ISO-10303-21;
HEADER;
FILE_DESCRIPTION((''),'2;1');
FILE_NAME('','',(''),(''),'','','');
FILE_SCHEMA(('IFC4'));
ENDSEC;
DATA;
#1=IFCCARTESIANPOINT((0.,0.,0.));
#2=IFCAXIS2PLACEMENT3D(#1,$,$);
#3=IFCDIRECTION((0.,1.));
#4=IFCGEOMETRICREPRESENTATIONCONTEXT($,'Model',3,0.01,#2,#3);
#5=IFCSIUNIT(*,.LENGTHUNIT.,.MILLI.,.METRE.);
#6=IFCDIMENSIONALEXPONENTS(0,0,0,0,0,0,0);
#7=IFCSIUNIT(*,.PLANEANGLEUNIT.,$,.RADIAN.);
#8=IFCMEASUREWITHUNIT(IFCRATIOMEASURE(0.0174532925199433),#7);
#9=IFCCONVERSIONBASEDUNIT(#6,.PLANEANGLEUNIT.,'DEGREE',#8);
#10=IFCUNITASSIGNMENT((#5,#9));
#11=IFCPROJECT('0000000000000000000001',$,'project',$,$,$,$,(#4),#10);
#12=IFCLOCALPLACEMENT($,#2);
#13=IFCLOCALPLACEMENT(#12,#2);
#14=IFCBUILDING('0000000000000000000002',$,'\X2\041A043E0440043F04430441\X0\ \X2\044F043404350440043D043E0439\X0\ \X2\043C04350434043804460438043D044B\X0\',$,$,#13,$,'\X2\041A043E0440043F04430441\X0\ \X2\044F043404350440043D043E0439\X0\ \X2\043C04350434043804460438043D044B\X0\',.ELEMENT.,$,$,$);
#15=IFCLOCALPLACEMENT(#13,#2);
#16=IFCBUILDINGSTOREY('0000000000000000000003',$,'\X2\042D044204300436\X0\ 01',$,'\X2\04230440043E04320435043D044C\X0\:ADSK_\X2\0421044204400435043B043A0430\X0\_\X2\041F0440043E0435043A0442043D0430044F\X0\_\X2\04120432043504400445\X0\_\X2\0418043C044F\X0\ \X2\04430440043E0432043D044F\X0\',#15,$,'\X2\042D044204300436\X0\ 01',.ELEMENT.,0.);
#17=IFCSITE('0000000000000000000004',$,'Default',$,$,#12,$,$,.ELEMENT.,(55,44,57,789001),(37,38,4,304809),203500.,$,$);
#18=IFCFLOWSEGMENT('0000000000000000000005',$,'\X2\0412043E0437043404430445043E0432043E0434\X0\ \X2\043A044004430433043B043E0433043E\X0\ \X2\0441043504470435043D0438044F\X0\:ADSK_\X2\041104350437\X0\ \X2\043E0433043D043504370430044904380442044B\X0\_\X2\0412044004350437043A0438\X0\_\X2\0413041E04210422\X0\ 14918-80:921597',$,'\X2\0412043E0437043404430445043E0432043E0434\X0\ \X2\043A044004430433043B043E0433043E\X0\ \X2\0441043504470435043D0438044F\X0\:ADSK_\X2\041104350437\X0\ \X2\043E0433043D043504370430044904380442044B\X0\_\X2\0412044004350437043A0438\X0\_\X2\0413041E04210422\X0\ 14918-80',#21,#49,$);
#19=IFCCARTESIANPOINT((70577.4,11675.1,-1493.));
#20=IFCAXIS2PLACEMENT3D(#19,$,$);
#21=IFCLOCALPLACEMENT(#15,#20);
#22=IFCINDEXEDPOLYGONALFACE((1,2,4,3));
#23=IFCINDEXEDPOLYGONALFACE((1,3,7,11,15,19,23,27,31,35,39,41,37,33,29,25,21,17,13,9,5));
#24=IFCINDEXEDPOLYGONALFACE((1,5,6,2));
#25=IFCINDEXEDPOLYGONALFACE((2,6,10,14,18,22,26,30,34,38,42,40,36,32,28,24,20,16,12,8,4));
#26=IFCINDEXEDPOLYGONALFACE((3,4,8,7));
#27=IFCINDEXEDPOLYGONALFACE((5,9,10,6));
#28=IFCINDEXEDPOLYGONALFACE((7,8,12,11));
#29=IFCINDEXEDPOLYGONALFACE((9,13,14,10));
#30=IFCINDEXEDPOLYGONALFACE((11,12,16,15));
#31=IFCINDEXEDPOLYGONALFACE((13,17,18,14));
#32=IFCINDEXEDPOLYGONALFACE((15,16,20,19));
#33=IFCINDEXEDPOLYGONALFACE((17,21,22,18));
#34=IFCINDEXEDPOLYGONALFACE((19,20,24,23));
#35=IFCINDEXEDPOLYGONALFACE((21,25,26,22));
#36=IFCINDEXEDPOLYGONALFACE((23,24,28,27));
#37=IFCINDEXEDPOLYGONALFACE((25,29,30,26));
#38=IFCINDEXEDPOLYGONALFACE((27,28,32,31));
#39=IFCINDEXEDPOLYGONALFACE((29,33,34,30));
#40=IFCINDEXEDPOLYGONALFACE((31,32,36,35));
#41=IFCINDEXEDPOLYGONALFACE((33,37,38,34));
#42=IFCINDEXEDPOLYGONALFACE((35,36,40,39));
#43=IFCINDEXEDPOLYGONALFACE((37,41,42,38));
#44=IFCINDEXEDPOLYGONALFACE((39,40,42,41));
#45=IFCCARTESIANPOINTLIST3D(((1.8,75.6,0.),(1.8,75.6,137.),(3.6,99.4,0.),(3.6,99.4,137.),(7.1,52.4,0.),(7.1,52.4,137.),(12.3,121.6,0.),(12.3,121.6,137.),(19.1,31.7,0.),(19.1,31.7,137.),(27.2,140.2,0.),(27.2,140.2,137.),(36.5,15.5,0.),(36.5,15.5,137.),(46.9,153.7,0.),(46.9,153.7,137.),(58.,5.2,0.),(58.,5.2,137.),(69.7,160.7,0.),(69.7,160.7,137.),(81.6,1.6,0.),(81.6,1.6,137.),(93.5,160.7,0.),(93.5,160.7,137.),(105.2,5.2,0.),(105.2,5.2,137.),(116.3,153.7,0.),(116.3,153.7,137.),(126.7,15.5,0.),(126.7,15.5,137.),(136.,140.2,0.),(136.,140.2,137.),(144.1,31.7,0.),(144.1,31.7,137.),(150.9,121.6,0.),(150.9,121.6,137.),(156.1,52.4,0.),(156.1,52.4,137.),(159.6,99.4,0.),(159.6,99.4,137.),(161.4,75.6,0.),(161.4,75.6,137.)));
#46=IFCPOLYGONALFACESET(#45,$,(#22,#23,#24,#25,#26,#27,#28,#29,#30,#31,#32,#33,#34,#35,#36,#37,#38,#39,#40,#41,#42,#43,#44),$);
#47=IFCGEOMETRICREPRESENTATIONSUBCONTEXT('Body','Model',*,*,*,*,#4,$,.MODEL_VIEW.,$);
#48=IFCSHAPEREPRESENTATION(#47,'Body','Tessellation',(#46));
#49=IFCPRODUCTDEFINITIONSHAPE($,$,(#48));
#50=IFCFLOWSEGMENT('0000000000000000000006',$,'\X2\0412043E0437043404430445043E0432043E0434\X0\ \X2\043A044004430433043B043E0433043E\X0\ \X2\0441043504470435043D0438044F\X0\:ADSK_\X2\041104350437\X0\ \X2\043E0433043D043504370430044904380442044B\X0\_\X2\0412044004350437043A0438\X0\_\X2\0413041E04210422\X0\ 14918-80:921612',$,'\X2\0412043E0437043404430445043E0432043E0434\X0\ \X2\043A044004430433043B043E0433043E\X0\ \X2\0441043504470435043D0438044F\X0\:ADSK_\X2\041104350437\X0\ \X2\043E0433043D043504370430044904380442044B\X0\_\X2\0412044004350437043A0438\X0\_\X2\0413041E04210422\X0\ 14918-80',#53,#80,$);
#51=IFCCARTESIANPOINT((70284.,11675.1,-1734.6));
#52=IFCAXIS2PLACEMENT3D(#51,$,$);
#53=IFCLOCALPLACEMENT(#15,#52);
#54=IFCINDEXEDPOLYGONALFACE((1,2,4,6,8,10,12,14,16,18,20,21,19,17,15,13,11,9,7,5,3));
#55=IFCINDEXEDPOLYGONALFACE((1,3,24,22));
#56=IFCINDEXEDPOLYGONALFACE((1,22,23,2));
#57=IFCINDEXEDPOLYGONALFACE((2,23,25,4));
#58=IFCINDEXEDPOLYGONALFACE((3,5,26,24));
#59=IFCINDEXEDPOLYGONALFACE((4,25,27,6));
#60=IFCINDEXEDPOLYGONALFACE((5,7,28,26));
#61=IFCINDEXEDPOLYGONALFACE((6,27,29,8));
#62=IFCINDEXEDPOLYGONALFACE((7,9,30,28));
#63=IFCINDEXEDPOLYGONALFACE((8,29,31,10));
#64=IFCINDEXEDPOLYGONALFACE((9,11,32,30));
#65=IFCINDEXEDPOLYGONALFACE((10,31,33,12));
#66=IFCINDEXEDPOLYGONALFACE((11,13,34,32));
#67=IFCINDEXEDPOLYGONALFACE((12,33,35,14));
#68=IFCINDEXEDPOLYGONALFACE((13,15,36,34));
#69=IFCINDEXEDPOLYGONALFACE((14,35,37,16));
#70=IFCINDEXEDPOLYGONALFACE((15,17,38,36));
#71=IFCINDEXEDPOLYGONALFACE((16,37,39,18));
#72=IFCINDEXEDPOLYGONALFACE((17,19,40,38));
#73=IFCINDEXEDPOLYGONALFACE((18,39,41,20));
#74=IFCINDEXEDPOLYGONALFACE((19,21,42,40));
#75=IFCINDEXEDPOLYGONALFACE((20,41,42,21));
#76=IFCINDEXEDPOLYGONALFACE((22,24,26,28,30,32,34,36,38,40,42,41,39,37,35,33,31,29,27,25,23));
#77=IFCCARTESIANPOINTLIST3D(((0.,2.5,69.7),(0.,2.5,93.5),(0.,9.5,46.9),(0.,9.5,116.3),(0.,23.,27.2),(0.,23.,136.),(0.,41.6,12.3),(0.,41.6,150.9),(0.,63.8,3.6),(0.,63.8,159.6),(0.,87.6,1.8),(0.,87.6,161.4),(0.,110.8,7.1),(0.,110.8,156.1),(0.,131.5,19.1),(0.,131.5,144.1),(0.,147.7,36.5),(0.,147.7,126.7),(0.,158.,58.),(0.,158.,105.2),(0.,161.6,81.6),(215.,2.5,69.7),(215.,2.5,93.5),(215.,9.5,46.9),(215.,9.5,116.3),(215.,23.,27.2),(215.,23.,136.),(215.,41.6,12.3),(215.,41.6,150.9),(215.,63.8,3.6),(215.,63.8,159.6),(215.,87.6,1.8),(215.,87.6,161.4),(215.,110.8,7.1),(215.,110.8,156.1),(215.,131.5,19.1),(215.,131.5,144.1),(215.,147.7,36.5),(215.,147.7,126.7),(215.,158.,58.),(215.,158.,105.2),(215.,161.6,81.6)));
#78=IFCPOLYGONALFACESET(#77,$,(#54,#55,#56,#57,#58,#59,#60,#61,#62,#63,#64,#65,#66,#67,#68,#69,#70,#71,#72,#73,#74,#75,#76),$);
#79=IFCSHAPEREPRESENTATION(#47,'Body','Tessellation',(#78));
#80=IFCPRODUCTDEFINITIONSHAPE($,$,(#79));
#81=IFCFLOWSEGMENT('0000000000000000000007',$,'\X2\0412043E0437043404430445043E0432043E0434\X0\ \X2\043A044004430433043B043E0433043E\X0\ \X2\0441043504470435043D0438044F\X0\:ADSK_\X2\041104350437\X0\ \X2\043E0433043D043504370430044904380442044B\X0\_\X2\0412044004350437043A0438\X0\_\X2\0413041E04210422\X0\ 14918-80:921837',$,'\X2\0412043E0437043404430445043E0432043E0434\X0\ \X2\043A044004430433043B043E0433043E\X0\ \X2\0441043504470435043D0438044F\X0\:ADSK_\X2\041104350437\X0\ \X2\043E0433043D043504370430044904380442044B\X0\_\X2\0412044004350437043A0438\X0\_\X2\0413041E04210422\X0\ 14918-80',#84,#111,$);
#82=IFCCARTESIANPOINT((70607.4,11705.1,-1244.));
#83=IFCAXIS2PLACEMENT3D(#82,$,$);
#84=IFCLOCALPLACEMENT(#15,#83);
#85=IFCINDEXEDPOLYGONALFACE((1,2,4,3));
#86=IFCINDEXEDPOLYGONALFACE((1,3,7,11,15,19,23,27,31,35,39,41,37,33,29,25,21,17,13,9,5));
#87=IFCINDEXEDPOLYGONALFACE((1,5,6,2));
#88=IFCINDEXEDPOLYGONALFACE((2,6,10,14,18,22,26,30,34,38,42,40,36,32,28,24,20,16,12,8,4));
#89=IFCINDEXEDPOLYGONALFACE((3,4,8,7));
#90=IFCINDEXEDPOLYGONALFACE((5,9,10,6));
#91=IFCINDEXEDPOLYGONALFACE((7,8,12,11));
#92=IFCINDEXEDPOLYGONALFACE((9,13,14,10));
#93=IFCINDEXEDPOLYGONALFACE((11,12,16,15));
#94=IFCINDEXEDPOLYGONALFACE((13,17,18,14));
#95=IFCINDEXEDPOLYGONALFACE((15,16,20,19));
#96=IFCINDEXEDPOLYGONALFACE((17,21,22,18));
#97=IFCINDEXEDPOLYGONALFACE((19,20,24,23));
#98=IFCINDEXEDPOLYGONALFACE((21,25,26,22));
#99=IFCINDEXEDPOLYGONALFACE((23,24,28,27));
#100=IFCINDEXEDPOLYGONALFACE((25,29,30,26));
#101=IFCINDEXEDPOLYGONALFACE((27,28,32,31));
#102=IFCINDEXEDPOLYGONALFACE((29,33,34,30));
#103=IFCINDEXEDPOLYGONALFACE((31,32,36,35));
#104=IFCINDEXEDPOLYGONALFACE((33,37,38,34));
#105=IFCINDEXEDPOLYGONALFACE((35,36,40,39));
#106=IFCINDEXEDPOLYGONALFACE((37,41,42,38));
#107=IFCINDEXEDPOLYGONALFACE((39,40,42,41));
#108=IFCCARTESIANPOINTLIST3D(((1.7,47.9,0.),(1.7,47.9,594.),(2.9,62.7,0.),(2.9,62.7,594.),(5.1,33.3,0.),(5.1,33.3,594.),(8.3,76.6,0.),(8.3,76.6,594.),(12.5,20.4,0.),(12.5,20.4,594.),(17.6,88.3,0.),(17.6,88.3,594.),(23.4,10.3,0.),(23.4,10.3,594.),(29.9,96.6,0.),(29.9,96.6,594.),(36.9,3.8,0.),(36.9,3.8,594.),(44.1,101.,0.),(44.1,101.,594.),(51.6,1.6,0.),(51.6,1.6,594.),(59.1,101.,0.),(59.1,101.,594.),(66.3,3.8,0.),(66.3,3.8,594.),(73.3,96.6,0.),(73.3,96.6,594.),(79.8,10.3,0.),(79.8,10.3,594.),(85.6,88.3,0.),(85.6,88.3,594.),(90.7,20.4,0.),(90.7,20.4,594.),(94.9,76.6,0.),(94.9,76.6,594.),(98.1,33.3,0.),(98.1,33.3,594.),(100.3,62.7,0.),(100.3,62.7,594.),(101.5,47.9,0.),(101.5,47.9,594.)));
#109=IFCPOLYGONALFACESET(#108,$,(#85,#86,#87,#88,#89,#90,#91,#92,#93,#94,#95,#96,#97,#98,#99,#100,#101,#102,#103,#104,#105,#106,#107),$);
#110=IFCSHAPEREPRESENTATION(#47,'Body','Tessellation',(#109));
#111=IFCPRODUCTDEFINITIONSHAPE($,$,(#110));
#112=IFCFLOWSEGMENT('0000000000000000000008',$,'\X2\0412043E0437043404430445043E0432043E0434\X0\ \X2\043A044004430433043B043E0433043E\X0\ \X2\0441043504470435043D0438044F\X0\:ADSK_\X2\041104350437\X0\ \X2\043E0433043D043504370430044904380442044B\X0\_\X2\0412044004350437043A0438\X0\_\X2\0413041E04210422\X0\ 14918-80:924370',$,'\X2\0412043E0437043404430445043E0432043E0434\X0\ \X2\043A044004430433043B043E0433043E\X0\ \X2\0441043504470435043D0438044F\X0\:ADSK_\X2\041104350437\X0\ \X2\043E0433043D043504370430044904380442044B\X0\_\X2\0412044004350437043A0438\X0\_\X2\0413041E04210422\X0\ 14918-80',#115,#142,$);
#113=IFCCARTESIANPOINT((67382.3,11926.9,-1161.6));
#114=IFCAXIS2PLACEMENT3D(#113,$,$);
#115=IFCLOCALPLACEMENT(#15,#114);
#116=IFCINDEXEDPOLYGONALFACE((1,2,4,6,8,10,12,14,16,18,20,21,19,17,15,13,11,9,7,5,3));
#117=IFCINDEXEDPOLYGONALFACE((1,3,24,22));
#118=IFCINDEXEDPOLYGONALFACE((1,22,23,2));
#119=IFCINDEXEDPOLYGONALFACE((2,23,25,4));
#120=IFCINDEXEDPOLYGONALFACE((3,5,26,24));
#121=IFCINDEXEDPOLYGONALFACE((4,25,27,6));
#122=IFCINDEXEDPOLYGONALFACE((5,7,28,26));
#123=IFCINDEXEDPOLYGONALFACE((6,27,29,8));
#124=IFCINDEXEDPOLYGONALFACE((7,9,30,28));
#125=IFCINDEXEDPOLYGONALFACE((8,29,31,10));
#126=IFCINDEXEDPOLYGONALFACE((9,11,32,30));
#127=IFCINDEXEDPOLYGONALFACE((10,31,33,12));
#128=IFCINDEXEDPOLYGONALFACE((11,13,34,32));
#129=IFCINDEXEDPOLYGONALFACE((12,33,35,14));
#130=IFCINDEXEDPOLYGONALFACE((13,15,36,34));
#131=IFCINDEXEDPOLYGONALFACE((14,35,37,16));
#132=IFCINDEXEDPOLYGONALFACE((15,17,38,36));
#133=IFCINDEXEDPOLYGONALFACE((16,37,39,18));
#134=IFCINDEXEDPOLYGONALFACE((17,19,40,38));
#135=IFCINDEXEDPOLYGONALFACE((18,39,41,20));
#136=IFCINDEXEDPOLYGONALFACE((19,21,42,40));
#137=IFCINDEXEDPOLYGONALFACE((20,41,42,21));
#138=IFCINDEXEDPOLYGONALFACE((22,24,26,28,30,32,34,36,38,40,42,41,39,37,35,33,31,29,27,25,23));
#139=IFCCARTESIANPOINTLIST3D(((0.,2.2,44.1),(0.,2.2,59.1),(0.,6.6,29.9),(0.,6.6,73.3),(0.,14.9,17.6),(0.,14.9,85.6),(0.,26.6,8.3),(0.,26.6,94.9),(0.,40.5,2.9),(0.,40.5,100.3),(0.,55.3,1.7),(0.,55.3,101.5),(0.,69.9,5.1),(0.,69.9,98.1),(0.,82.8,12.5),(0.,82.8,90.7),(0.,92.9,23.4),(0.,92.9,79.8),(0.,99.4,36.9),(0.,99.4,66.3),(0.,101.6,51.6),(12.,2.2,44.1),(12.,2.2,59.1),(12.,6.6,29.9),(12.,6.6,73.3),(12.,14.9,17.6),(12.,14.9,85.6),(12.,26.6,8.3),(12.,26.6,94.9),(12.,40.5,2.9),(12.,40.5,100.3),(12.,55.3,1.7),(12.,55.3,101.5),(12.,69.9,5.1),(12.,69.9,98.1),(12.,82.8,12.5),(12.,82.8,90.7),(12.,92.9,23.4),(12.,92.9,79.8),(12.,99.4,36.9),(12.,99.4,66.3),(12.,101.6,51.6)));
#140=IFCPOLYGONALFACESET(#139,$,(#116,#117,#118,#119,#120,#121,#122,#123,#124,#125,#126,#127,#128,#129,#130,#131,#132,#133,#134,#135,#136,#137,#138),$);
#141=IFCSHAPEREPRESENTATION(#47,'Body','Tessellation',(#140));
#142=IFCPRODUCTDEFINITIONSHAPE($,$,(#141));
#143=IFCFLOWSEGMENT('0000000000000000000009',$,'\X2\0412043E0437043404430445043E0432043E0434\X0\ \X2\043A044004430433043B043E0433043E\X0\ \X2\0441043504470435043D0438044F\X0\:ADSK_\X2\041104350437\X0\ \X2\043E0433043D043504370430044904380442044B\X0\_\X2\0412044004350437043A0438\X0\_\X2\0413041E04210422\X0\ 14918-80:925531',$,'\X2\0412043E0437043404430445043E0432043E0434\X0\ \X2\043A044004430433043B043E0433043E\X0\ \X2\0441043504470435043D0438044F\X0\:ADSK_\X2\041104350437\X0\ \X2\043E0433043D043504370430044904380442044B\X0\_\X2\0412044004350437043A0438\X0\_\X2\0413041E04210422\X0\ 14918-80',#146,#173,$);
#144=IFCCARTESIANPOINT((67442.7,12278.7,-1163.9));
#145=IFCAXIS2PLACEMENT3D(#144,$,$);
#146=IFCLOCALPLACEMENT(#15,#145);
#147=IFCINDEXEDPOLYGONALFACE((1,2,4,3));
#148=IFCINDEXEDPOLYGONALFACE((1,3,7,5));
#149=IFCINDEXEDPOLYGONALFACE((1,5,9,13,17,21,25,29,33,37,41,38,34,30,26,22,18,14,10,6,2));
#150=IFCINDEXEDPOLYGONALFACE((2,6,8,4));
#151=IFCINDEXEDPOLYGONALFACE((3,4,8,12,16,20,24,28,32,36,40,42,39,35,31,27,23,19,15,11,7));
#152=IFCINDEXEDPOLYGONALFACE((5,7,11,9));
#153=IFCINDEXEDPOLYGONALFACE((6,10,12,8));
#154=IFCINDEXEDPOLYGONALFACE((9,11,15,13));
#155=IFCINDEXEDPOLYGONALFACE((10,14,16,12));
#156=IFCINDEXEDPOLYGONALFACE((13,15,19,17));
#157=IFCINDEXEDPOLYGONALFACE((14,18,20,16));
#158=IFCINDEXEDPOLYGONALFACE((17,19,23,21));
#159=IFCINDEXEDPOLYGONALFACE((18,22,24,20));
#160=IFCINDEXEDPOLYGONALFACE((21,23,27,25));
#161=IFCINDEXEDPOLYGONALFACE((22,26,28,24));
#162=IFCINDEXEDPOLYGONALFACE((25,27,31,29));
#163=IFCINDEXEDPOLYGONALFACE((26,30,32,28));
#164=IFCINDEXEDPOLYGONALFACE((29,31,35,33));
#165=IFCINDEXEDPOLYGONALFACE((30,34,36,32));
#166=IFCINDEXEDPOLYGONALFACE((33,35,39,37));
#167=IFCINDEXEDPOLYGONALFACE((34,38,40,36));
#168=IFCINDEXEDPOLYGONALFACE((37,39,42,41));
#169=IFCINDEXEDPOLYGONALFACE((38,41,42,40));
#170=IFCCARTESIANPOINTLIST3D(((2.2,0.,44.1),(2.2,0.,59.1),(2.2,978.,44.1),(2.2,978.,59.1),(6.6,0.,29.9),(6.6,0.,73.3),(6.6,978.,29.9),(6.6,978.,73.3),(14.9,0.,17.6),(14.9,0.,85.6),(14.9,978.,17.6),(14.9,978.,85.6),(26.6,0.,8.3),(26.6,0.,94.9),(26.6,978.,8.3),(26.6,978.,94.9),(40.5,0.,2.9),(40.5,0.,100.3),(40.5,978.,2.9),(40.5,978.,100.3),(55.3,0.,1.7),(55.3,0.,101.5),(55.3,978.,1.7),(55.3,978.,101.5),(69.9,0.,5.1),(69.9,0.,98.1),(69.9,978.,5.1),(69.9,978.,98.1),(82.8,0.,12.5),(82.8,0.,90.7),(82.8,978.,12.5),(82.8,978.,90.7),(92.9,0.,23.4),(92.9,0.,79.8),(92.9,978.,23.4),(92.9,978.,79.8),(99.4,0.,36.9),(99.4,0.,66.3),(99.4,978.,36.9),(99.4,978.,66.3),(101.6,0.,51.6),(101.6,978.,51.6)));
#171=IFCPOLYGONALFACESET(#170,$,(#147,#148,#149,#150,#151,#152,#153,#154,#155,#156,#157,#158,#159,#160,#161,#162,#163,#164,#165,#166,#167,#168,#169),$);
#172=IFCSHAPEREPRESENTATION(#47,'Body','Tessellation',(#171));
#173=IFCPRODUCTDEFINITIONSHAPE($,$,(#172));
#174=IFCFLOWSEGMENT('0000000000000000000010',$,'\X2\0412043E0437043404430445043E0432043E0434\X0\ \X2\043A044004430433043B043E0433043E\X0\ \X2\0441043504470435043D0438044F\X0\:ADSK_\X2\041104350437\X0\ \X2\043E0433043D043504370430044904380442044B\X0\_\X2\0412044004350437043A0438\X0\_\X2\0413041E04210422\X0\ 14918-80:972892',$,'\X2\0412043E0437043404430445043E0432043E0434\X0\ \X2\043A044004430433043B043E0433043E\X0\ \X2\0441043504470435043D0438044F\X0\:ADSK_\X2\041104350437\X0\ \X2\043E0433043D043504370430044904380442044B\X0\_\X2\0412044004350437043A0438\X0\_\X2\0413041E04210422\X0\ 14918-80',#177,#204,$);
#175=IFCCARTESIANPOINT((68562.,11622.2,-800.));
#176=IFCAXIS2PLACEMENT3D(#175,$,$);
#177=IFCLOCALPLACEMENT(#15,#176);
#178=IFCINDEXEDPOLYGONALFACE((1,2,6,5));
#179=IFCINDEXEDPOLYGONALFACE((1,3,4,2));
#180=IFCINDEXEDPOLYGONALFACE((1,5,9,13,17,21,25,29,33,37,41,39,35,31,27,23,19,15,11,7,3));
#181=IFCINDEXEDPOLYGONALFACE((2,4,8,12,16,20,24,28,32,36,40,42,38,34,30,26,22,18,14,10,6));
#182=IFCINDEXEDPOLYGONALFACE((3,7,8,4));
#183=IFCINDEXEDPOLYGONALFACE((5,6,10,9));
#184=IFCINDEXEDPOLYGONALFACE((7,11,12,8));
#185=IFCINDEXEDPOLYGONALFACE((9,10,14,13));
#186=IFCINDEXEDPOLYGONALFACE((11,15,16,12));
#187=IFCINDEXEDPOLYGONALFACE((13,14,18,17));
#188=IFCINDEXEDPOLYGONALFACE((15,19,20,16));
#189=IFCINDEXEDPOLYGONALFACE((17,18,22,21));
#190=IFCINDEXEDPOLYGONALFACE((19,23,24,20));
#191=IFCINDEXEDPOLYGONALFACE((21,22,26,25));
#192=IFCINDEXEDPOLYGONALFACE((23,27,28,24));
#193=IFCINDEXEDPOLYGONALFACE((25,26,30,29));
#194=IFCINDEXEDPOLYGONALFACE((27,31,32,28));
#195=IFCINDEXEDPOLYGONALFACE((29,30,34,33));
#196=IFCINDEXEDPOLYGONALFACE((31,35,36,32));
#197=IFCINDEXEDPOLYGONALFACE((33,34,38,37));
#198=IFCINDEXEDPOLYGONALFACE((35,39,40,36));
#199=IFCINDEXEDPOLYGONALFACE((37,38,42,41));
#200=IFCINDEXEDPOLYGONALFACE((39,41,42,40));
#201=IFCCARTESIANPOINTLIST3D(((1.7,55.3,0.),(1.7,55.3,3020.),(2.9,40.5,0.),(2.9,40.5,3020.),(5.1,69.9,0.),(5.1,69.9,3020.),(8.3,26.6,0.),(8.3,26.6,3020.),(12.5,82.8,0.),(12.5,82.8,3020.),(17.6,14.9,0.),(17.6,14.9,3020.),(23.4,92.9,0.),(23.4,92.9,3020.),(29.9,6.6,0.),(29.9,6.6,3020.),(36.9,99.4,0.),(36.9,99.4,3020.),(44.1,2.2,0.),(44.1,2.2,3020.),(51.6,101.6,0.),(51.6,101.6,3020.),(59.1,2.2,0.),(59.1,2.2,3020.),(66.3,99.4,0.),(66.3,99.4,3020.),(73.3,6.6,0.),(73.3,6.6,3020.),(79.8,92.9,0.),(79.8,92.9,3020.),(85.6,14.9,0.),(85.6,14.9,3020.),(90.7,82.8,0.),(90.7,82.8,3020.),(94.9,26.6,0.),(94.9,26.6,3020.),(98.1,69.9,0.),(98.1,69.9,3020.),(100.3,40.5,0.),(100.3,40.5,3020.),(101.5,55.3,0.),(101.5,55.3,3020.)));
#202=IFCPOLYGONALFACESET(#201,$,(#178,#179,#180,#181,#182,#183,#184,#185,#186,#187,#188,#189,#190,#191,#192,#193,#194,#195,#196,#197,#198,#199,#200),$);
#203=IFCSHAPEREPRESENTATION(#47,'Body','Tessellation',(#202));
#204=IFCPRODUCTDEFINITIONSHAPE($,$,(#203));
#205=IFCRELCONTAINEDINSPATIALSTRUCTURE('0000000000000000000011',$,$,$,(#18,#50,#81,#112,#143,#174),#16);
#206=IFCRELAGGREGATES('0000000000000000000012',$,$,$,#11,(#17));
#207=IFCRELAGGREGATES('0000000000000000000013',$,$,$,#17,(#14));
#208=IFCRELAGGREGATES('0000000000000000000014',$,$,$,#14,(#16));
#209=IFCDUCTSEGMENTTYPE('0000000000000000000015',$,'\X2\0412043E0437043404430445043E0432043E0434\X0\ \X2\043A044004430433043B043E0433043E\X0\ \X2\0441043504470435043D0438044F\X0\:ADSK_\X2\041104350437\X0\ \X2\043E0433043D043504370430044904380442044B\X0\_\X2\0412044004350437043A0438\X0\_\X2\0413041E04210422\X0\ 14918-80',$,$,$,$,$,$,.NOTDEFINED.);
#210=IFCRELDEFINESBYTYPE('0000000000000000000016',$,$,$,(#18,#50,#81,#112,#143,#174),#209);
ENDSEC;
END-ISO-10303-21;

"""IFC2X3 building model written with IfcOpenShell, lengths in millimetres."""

from ifc_helpers import new_model, entity, si_unit, converted_unit, direction, frame, origin, origin_2d_with_axis, place, context, subcontext, project, spatial, circle, extrude, type_object, element, save


model = new_model("IFC2X3")

# Units and contexts
model_context = context("Model", 3, precision=0.01, world=origin(), true_north=direction((0.0, 1.0)))
body_context = subcontext(model_context, "Body", "Model", "MODEL_VIEW")
ifc_project = project(units=[si_unit("LENGTHUNIT", "METRE", prefix="MILLI"), converted_unit("PLANEANGLEUNIT", "DEGREE", entity("IfcRatioMeasure", 0.0174532925199433), si_unit("PLANEANGLEUNIT", "RADIAN"), dimensions=[0, 0, 0, 0, 0, 0, 0])], contexts=[model_context])

# Site, building, storey
site_placement = place(None, origin())
site = spatial("IfcSite", under=ifc_project, at=site_placement, Name="Default", CompositionType="ELEMENT", RefLatitude=(55, 44, 57, 789001), RefLongitude=(37, 38, 4, 304809), RefElevation=203500.0)
building_placement = place(site_placement, origin())
building = spatial("IfcBuilding", under=site, at=building_placement, Name="Корпус ядерной медицины", LongName="Корпус ядерной медицины", CompositionType="ELEMENT")
storey_placement = place(building_placement, origin())
storey = spatial("IfcBuildingStorey", under=building, at=storey_placement, Name="Этаж 01", ObjectType="Уровень:ADSK_Стрелка_Проектная_Вверх_Имя уровня", LongName="Этаж 01", CompositionType="ELEMENT", Elevation=0.0)

# Flow segments
duct_segment_type_1 = type_object("IfcDuctSegmentType", Name="Воздуховод круглого сечения:ADSK_Без огнезащиты_Врезки_ГОСТ 14918-80", PredefinedType="NOTDEFINED")
flow_segment_1_placement = place(storey_placement, frame((70577.4, 11675.1, -1493.0)))
element("IfcFlowSegment", 1, at=flow_segment_1_placement, inside=storey, type_object=duct_segment_type_1, Name="Воздуховод круглого сечения:ADSK_Без огнезащиты_Врезки_ГОСТ 14918-80:921597", ObjectType="Воздуховод круглого сечения:ADSK_Без огнезащиты_Врезки_ГОСТ 14918-80", context=body_context, shape_type="SweptSolid", body=[
    extrude(circle(Radius=80.0, at=origin_2d_with_axis()), frame((81.6, 81.6, 0.0), z_axis=(0.0, 0.0, 1.0), x_axis=(0.0, -1.0, 0.0)), (0.0, 0.0, 1.0), 137.0),
])
flow_segment_2_placement = place(storey_placement, frame((70284.0, 11675.1, -1734.6)))
element("IfcFlowSegment", 2, at=flow_segment_2_placement, inside=storey, type_object=duct_segment_type_1, Name="Воздуховод круглого сечения:ADSK_Без огнезащиты_Врезки_ГОСТ 14918-80:921612", ObjectType="Воздуховод круглого сечения:ADSK_Без огнезащиты_Врезки_ГОСТ 14918-80", context=body_context, shape_type="SweptSolid", body=[
    extrude(circle(Radius=80.0, at=origin_2d_with_axis()), frame((0.0, 81.6, 81.6), z_axis=(1.0, 0.0, 0.0), x_axis=(0.0, 1.0, 0.0)), (0.0, 0.0, 1.0), 215.0),
])
flow_segment_3_placement = place(storey_placement, frame((70607.4, 11705.1, -1244.0)))
element("IfcFlowSegment", 3, at=flow_segment_3_placement, inside=storey, type_object=duct_segment_type_1, Name="Воздуховод круглого сечения:ADSK_Без огнезащиты_Врезки_ГОСТ 14918-80:921837", ObjectType="Воздуховод круглого сечения:ADSK_Без огнезащиты_Врезки_ГОСТ 14918-80", context=body_context, shape_type="SweptSolid", body=[
    extrude(circle(Radius=50.0, at=origin_2d_with_axis()), frame((51.6, 51.6, 0.0), z_axis=(0.0, 0.0, 1.0), x_axis=(0.0, -1.0, 0.0)), (0.0, 0.0, 1.0), 594.0),
])
flow_segment_4_placement = place(storey_placement, frame((67382.3, 11926.9, -1161.6)))
element("IfcFlowSegment", 4, at=flow_segment_4_placement, inside=storey, type_object=duct_segment_type_1, Name="Воздуховод круглого сечения:ADSK_Без огнезащиты_Врезки_ГОСТ 14918-80:924370", ObjectType="Воздуховод круглого сечения:ADSK_Без огнезащиты_Врезки_ГОСТ 14918-80", context=body_context, shape_type="SweptSolid", body=[
    extrude(circle(Radius=50.0, at=origin_2d_with_axis()), frame((0.0, 51.6, 51.6), z_axis=(1.0, 0.0, 0.0), x_axis=(0.0, 1.0, 0.0)), (0.0, 0.0, 1.0), 12.0),
])
flow_segment_5_placement = place(storey_placement, frame((67442.7, 12278.7, -1163.9)))
element("IfcFlowSegment", 5, at=flow_segment_5_placement, inside=storey, type_object=duct_segment_type_1, Name="Воздуховод круглого сечения:ADSK_Без огнезащиты_Врезки_ГОСТ 14918-80:925531", ObjectType="Воздуховод круглого сечения:ADSK_Без огнезащиты_Врезки_ГОСТ 14918-80", context=body_context, shape_type="SweptSolid", body=[
    extrude(circle(Radius=50.0, at=origin_2d_with_axis()), frame((51.6, 0.0, 51.6), z_axis=(0.0, 1.0, 0.0), x_axis=(1.0, 0.0, 0.0)), (0.0, 0.0, 1.0), 978.0),
])
flow_segment_6_placement = place(storey_placement, frame((68562.0, 11622.2, -800.0)))
element("IfcFlowSegment", 6, at=flow_segment_6_placement, inside=storey, type_object=duct_segment_type_1, Name="Воздуховод круглого сечения:ADSK_Без огнезащиты_Врезки_ГОСТ 14918-80:972892", ObjectType="Воздуховод круглого сечения:ADSK_Без огнезащиты_Врезки_ГОСТ 14918-80", context=body_context, shape_type="SweptSolid", body=[
    extrude(circle(Radius=50.0, at=origin_2d_with_axis()), frame((51.6, 51.6, 0.0), z_axis=(0.0, 0.0, 1.0), x_axis=(0.0, 1.0, 0.0)), (0.0, 0.0, 1.0), 3020.0),
])

save(model, "model.ifc")
